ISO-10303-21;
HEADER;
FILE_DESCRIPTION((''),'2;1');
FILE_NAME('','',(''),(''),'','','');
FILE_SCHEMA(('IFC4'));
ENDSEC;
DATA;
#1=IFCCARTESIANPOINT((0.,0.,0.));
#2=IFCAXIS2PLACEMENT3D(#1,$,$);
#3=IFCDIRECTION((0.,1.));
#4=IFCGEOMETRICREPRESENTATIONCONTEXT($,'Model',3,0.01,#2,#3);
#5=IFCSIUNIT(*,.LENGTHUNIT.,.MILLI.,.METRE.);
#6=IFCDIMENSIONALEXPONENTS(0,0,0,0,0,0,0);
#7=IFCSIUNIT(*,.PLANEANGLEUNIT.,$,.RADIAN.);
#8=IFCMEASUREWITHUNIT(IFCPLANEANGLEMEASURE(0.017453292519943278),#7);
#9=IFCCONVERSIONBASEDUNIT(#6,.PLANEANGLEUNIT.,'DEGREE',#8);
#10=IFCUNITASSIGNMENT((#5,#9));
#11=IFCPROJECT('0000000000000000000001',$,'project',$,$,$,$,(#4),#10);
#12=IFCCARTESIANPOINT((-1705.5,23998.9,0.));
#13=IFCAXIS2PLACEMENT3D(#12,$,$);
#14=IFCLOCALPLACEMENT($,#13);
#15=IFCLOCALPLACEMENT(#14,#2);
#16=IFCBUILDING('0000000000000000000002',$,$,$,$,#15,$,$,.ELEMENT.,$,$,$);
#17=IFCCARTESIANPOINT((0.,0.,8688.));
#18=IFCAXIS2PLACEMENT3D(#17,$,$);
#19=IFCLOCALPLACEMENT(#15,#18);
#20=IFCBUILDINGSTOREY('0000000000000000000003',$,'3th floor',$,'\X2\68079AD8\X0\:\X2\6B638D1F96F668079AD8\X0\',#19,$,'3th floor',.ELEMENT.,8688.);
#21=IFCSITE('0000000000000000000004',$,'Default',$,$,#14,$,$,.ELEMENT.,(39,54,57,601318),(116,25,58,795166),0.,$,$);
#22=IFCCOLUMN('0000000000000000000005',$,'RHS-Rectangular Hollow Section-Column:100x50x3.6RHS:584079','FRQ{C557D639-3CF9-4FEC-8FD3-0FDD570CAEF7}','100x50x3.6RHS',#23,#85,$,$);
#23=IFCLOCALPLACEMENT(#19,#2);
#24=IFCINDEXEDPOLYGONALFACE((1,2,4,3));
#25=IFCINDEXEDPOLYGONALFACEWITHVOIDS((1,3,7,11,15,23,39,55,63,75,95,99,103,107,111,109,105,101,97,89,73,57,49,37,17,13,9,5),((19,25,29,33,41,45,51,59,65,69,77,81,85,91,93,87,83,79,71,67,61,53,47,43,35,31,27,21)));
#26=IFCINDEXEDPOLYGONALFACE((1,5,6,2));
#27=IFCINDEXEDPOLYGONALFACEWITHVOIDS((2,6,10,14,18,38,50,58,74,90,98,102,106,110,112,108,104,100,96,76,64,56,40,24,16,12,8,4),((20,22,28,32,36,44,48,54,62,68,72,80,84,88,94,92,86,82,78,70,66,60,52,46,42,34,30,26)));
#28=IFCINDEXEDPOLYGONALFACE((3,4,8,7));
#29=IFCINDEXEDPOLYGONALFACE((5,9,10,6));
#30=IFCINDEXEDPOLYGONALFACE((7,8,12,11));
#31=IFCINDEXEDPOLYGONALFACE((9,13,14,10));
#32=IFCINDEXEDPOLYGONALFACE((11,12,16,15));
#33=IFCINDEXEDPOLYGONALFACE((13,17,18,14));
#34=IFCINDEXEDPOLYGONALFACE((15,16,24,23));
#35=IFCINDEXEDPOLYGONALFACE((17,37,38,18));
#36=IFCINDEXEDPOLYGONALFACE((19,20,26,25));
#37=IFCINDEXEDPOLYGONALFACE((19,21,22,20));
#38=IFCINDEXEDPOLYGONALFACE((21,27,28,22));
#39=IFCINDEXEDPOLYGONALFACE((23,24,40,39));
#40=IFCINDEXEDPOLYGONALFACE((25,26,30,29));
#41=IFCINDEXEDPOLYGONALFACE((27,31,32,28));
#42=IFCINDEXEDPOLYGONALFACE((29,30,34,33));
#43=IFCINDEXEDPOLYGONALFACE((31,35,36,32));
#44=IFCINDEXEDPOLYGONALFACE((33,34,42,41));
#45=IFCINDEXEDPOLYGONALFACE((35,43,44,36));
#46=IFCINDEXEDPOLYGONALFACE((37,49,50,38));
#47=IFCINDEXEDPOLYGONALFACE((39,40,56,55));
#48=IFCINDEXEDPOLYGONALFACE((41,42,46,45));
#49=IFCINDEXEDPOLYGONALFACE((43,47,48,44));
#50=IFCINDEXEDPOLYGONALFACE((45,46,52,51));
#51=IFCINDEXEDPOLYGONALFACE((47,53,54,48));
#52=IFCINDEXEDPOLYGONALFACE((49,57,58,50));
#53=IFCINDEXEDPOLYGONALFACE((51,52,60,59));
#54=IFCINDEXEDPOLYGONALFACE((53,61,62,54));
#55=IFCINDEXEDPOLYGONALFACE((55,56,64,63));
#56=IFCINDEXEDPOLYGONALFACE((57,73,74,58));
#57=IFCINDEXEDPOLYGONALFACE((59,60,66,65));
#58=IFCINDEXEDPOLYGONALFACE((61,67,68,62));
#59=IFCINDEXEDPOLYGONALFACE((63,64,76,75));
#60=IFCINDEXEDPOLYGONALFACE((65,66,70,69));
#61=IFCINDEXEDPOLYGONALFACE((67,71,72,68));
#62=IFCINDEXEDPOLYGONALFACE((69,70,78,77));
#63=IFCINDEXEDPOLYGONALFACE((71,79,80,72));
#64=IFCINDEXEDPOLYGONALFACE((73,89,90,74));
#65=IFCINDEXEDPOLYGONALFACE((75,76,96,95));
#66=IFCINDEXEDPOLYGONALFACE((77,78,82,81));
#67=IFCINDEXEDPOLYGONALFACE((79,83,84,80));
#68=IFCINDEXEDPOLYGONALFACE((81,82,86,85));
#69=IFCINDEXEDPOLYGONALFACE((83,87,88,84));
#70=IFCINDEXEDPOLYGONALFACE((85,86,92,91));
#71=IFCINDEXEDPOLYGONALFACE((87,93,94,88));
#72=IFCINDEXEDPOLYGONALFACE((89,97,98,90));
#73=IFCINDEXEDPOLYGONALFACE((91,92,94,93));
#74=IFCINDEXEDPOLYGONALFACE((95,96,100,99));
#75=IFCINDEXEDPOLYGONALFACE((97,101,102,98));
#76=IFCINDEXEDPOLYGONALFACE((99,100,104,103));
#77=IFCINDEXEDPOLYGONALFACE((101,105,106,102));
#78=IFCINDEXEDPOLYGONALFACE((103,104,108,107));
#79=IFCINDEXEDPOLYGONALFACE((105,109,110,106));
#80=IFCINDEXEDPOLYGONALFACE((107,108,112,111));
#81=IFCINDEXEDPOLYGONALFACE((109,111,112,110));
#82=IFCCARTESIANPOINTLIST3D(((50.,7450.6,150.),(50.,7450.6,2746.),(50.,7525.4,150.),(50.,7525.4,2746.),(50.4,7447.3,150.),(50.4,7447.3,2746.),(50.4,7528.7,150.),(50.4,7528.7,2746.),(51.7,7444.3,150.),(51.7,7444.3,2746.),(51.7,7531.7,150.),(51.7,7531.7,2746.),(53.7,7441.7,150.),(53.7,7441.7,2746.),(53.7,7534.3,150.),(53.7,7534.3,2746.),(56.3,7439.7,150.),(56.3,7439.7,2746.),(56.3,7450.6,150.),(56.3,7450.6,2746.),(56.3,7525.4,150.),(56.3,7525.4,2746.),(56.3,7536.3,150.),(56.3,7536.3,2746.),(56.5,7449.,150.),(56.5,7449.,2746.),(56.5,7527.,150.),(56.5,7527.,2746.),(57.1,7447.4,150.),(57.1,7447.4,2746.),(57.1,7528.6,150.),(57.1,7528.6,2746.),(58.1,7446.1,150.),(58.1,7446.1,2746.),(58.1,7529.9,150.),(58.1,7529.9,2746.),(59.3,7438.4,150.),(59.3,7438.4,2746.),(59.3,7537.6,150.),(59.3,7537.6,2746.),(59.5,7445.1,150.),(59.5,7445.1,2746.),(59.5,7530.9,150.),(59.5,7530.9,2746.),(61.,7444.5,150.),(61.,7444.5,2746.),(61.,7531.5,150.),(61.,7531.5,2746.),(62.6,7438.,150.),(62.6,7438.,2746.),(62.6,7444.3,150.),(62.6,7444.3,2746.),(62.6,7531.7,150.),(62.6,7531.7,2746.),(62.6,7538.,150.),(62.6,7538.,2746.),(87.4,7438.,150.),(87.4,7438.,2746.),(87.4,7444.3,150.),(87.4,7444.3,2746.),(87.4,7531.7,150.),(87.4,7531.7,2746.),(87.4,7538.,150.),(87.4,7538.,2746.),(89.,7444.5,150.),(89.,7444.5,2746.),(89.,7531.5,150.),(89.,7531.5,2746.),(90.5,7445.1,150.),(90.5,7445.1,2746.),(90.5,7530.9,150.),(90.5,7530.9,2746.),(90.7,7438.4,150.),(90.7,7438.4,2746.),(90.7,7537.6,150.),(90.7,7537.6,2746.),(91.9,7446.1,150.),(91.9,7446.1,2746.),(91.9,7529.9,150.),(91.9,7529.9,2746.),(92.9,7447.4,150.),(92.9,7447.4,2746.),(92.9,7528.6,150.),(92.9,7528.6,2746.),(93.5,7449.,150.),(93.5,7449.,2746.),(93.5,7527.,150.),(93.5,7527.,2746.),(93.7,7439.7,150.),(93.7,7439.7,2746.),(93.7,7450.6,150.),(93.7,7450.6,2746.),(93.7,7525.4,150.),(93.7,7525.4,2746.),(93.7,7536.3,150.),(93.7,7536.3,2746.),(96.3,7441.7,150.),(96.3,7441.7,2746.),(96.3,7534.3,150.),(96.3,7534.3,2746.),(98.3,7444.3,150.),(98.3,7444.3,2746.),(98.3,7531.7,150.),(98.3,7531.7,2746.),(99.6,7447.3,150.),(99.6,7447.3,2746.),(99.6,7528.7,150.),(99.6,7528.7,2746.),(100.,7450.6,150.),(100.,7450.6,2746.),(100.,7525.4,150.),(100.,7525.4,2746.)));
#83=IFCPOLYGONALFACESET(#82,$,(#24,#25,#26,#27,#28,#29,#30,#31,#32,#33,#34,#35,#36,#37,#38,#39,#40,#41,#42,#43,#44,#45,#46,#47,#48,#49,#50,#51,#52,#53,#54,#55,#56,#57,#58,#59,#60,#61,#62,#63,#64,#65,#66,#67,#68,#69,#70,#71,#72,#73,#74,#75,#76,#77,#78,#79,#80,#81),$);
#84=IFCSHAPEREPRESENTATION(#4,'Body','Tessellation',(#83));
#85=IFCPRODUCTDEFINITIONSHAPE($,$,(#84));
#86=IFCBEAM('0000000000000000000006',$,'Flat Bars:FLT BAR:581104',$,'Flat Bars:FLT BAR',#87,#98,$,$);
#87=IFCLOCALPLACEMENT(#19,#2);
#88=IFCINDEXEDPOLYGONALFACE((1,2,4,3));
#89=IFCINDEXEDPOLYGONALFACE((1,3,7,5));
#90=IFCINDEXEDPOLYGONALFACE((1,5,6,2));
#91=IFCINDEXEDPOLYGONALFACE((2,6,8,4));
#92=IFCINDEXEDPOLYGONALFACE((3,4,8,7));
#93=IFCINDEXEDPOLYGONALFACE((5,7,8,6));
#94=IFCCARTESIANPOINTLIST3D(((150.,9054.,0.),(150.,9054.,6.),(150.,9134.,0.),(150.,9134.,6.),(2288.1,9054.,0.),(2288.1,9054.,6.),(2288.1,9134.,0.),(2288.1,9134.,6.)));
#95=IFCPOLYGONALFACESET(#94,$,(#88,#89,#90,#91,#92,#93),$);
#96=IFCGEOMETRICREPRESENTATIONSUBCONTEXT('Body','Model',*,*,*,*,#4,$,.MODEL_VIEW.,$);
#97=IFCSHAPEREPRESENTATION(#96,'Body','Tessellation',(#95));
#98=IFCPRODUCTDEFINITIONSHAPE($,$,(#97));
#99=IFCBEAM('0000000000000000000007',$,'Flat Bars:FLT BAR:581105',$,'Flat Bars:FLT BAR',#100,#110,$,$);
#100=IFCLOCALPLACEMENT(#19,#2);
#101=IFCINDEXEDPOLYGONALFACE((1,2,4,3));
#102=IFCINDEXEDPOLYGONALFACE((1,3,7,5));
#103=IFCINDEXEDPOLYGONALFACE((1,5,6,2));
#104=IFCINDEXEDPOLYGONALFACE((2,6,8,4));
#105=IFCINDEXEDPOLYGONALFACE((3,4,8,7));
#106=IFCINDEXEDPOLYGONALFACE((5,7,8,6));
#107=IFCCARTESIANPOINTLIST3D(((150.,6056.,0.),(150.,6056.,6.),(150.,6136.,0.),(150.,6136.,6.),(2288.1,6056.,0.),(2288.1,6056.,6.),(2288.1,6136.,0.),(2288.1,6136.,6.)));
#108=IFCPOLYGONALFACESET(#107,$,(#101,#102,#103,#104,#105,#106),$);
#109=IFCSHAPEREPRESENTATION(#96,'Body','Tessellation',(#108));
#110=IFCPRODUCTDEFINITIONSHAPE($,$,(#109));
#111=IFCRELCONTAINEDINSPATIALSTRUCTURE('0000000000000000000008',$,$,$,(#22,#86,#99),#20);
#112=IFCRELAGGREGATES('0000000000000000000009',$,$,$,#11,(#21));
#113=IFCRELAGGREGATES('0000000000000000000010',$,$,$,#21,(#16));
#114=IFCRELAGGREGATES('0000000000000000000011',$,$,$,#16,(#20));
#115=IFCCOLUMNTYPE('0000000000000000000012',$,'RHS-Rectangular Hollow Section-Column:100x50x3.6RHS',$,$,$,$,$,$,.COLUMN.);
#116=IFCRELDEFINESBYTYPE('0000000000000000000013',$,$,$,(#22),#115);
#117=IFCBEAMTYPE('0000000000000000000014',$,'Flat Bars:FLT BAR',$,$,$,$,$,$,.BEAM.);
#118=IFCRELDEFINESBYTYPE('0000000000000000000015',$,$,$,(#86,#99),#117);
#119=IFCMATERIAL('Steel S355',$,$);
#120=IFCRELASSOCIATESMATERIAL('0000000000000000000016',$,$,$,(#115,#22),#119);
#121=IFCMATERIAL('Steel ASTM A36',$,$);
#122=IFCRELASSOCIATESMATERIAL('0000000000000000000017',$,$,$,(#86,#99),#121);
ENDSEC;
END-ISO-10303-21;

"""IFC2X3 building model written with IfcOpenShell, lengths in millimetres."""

from ifc_helpers import new_model, entity, si_unit, converted_unit, direction, frame, origin, origin_2d, origin_2d_with_axis, place, context, subcontext, project, spatial, rectangle, hollow_rectangle, extrude, clip, halfspace, material, type_object, element, save


model = new_model("IFC2X3")

# Units and contexts
model_context = context("Model", 3, precision=0.01, world=origin(), true_north=direction((0.0, 1.0)))
body_context = subcontext(model_context, "Body", "Model", "MODEL_VIEW")
ifc_project = project(units=[si_unit("LENGTHUNIT", "METRE", prefix="MILLI"), converted_unit("PLANEANGLEUNIT", "DEGREE", entity("IfcPlaneAngleMeasure", 0.017453292519943278), si_unit("PLANEANGLEUNIT", "RADIAN"), dimensions=[0, 0, 0, 0, 0, 0, 0])], contexts=[model_context])

# Site, building, storey
site_placement = place(None, frame((-1705.5, 23998.9, 0.0)))
site = spatial("IfcSite", under=ifc_project, at=site_placement, Name="Default", CompositionType="ELEMENT", RefLatitude=(39, 54, 57, 601318), RefLongitude=(116, 25, 58, 795166), RefElevation=0.0)
building_placement = place(site_placement, origin())
building = spatial("IfcBuilding", under=site, at=building_placement, CompositionType="ELEMENT")
storey_placement = place(building_placement, frame((0.0, 0.0, 8688.0)))
storey = spatial("IfcBuildingStorey", under=building, at=storey_placement, Name="3th floor", ObjectType="标高:正负零标高", LongName="3th floor", CompositionType="ELEMENT", Elevation=8688.0)

# Column
ifc_material_1 = material(Name="Steel S355")
column_type = type_object("IfcColumnType", Name="RHS-Rectangular Hollow Section-Column:100x50x3.6RHS", PredefinedType="COLUMN", material=ifc_material_1)
column_1_placement = place(storey_placement, frame((75.0, 7488.0, 2746.0), z_axis=(0.0, 0.0, 1.0), x_axis=(-1.0, 0.0, 0.0)))
element("IfcColumn", 1, at=column_1_placement, inside=storey, type_object=column_type, material=ifc_material_1, Name="RHS-Rectangular Hollow Section-Column:100x50x3.6RHS:584079", Description="FRQ{C557D639-3CF9-4FEC-8FD3-0FDD570CAEF7}", ObjectType="100x50x3.6RHS", context=model_context, shape_type="Clipping", body=[
    clip(extrude(hollow_rectangle(XDim=50.0, YDim=100.0, WallThickness=6.3, InnerFilletRadius=6.3, OuterFilletRadius=12.6, at=origin_2d()), origin(), (0.0, 0.0, -1.0), 2651.9), halfspace(frame((75.0, 7488.0, -2596.0), z_axis=(0.0, 0.0, 1.0), x_axis=(-1.0, 0.0, 0.0)), True)),
])

# Beams
ifc_material_2 = material(Name="Steel ASTM A36")
beam_type = type_object("IfcBeamType", Name="Flat Bars:FLT BAR", PredefinedType="BEAM")
for number, where, name in (
    (2, (150.0, 9094.0, 6.0), "Flat Bars:FLT BAR:581104"),
    (3, (150.0, 6096.0, 6.0), "Flat Bars:FLT BAR:581105"),
):
    element("IfcBeam", number, at=place(storey_placement, frame(where)), inside=storey, type_object=beam_type, material=ifc_material_2, Name=name, ObjectType="Flat Bars:FLT BAR", context=body_context, shape_type="SweptSolid", body=[
        extrude(rectangle(XDim=6.0, YDim=80.0, at=origin_2d_with_axis()), frame((0.0, 0.0, -3.0), z_axis=(1.0, 0.0, 0.0), x_axis=(0.0, 0.0, -1.0)), (0.0, 0.0, 1.0), 2138.1),
    ])

save(model, "model.ifc")
